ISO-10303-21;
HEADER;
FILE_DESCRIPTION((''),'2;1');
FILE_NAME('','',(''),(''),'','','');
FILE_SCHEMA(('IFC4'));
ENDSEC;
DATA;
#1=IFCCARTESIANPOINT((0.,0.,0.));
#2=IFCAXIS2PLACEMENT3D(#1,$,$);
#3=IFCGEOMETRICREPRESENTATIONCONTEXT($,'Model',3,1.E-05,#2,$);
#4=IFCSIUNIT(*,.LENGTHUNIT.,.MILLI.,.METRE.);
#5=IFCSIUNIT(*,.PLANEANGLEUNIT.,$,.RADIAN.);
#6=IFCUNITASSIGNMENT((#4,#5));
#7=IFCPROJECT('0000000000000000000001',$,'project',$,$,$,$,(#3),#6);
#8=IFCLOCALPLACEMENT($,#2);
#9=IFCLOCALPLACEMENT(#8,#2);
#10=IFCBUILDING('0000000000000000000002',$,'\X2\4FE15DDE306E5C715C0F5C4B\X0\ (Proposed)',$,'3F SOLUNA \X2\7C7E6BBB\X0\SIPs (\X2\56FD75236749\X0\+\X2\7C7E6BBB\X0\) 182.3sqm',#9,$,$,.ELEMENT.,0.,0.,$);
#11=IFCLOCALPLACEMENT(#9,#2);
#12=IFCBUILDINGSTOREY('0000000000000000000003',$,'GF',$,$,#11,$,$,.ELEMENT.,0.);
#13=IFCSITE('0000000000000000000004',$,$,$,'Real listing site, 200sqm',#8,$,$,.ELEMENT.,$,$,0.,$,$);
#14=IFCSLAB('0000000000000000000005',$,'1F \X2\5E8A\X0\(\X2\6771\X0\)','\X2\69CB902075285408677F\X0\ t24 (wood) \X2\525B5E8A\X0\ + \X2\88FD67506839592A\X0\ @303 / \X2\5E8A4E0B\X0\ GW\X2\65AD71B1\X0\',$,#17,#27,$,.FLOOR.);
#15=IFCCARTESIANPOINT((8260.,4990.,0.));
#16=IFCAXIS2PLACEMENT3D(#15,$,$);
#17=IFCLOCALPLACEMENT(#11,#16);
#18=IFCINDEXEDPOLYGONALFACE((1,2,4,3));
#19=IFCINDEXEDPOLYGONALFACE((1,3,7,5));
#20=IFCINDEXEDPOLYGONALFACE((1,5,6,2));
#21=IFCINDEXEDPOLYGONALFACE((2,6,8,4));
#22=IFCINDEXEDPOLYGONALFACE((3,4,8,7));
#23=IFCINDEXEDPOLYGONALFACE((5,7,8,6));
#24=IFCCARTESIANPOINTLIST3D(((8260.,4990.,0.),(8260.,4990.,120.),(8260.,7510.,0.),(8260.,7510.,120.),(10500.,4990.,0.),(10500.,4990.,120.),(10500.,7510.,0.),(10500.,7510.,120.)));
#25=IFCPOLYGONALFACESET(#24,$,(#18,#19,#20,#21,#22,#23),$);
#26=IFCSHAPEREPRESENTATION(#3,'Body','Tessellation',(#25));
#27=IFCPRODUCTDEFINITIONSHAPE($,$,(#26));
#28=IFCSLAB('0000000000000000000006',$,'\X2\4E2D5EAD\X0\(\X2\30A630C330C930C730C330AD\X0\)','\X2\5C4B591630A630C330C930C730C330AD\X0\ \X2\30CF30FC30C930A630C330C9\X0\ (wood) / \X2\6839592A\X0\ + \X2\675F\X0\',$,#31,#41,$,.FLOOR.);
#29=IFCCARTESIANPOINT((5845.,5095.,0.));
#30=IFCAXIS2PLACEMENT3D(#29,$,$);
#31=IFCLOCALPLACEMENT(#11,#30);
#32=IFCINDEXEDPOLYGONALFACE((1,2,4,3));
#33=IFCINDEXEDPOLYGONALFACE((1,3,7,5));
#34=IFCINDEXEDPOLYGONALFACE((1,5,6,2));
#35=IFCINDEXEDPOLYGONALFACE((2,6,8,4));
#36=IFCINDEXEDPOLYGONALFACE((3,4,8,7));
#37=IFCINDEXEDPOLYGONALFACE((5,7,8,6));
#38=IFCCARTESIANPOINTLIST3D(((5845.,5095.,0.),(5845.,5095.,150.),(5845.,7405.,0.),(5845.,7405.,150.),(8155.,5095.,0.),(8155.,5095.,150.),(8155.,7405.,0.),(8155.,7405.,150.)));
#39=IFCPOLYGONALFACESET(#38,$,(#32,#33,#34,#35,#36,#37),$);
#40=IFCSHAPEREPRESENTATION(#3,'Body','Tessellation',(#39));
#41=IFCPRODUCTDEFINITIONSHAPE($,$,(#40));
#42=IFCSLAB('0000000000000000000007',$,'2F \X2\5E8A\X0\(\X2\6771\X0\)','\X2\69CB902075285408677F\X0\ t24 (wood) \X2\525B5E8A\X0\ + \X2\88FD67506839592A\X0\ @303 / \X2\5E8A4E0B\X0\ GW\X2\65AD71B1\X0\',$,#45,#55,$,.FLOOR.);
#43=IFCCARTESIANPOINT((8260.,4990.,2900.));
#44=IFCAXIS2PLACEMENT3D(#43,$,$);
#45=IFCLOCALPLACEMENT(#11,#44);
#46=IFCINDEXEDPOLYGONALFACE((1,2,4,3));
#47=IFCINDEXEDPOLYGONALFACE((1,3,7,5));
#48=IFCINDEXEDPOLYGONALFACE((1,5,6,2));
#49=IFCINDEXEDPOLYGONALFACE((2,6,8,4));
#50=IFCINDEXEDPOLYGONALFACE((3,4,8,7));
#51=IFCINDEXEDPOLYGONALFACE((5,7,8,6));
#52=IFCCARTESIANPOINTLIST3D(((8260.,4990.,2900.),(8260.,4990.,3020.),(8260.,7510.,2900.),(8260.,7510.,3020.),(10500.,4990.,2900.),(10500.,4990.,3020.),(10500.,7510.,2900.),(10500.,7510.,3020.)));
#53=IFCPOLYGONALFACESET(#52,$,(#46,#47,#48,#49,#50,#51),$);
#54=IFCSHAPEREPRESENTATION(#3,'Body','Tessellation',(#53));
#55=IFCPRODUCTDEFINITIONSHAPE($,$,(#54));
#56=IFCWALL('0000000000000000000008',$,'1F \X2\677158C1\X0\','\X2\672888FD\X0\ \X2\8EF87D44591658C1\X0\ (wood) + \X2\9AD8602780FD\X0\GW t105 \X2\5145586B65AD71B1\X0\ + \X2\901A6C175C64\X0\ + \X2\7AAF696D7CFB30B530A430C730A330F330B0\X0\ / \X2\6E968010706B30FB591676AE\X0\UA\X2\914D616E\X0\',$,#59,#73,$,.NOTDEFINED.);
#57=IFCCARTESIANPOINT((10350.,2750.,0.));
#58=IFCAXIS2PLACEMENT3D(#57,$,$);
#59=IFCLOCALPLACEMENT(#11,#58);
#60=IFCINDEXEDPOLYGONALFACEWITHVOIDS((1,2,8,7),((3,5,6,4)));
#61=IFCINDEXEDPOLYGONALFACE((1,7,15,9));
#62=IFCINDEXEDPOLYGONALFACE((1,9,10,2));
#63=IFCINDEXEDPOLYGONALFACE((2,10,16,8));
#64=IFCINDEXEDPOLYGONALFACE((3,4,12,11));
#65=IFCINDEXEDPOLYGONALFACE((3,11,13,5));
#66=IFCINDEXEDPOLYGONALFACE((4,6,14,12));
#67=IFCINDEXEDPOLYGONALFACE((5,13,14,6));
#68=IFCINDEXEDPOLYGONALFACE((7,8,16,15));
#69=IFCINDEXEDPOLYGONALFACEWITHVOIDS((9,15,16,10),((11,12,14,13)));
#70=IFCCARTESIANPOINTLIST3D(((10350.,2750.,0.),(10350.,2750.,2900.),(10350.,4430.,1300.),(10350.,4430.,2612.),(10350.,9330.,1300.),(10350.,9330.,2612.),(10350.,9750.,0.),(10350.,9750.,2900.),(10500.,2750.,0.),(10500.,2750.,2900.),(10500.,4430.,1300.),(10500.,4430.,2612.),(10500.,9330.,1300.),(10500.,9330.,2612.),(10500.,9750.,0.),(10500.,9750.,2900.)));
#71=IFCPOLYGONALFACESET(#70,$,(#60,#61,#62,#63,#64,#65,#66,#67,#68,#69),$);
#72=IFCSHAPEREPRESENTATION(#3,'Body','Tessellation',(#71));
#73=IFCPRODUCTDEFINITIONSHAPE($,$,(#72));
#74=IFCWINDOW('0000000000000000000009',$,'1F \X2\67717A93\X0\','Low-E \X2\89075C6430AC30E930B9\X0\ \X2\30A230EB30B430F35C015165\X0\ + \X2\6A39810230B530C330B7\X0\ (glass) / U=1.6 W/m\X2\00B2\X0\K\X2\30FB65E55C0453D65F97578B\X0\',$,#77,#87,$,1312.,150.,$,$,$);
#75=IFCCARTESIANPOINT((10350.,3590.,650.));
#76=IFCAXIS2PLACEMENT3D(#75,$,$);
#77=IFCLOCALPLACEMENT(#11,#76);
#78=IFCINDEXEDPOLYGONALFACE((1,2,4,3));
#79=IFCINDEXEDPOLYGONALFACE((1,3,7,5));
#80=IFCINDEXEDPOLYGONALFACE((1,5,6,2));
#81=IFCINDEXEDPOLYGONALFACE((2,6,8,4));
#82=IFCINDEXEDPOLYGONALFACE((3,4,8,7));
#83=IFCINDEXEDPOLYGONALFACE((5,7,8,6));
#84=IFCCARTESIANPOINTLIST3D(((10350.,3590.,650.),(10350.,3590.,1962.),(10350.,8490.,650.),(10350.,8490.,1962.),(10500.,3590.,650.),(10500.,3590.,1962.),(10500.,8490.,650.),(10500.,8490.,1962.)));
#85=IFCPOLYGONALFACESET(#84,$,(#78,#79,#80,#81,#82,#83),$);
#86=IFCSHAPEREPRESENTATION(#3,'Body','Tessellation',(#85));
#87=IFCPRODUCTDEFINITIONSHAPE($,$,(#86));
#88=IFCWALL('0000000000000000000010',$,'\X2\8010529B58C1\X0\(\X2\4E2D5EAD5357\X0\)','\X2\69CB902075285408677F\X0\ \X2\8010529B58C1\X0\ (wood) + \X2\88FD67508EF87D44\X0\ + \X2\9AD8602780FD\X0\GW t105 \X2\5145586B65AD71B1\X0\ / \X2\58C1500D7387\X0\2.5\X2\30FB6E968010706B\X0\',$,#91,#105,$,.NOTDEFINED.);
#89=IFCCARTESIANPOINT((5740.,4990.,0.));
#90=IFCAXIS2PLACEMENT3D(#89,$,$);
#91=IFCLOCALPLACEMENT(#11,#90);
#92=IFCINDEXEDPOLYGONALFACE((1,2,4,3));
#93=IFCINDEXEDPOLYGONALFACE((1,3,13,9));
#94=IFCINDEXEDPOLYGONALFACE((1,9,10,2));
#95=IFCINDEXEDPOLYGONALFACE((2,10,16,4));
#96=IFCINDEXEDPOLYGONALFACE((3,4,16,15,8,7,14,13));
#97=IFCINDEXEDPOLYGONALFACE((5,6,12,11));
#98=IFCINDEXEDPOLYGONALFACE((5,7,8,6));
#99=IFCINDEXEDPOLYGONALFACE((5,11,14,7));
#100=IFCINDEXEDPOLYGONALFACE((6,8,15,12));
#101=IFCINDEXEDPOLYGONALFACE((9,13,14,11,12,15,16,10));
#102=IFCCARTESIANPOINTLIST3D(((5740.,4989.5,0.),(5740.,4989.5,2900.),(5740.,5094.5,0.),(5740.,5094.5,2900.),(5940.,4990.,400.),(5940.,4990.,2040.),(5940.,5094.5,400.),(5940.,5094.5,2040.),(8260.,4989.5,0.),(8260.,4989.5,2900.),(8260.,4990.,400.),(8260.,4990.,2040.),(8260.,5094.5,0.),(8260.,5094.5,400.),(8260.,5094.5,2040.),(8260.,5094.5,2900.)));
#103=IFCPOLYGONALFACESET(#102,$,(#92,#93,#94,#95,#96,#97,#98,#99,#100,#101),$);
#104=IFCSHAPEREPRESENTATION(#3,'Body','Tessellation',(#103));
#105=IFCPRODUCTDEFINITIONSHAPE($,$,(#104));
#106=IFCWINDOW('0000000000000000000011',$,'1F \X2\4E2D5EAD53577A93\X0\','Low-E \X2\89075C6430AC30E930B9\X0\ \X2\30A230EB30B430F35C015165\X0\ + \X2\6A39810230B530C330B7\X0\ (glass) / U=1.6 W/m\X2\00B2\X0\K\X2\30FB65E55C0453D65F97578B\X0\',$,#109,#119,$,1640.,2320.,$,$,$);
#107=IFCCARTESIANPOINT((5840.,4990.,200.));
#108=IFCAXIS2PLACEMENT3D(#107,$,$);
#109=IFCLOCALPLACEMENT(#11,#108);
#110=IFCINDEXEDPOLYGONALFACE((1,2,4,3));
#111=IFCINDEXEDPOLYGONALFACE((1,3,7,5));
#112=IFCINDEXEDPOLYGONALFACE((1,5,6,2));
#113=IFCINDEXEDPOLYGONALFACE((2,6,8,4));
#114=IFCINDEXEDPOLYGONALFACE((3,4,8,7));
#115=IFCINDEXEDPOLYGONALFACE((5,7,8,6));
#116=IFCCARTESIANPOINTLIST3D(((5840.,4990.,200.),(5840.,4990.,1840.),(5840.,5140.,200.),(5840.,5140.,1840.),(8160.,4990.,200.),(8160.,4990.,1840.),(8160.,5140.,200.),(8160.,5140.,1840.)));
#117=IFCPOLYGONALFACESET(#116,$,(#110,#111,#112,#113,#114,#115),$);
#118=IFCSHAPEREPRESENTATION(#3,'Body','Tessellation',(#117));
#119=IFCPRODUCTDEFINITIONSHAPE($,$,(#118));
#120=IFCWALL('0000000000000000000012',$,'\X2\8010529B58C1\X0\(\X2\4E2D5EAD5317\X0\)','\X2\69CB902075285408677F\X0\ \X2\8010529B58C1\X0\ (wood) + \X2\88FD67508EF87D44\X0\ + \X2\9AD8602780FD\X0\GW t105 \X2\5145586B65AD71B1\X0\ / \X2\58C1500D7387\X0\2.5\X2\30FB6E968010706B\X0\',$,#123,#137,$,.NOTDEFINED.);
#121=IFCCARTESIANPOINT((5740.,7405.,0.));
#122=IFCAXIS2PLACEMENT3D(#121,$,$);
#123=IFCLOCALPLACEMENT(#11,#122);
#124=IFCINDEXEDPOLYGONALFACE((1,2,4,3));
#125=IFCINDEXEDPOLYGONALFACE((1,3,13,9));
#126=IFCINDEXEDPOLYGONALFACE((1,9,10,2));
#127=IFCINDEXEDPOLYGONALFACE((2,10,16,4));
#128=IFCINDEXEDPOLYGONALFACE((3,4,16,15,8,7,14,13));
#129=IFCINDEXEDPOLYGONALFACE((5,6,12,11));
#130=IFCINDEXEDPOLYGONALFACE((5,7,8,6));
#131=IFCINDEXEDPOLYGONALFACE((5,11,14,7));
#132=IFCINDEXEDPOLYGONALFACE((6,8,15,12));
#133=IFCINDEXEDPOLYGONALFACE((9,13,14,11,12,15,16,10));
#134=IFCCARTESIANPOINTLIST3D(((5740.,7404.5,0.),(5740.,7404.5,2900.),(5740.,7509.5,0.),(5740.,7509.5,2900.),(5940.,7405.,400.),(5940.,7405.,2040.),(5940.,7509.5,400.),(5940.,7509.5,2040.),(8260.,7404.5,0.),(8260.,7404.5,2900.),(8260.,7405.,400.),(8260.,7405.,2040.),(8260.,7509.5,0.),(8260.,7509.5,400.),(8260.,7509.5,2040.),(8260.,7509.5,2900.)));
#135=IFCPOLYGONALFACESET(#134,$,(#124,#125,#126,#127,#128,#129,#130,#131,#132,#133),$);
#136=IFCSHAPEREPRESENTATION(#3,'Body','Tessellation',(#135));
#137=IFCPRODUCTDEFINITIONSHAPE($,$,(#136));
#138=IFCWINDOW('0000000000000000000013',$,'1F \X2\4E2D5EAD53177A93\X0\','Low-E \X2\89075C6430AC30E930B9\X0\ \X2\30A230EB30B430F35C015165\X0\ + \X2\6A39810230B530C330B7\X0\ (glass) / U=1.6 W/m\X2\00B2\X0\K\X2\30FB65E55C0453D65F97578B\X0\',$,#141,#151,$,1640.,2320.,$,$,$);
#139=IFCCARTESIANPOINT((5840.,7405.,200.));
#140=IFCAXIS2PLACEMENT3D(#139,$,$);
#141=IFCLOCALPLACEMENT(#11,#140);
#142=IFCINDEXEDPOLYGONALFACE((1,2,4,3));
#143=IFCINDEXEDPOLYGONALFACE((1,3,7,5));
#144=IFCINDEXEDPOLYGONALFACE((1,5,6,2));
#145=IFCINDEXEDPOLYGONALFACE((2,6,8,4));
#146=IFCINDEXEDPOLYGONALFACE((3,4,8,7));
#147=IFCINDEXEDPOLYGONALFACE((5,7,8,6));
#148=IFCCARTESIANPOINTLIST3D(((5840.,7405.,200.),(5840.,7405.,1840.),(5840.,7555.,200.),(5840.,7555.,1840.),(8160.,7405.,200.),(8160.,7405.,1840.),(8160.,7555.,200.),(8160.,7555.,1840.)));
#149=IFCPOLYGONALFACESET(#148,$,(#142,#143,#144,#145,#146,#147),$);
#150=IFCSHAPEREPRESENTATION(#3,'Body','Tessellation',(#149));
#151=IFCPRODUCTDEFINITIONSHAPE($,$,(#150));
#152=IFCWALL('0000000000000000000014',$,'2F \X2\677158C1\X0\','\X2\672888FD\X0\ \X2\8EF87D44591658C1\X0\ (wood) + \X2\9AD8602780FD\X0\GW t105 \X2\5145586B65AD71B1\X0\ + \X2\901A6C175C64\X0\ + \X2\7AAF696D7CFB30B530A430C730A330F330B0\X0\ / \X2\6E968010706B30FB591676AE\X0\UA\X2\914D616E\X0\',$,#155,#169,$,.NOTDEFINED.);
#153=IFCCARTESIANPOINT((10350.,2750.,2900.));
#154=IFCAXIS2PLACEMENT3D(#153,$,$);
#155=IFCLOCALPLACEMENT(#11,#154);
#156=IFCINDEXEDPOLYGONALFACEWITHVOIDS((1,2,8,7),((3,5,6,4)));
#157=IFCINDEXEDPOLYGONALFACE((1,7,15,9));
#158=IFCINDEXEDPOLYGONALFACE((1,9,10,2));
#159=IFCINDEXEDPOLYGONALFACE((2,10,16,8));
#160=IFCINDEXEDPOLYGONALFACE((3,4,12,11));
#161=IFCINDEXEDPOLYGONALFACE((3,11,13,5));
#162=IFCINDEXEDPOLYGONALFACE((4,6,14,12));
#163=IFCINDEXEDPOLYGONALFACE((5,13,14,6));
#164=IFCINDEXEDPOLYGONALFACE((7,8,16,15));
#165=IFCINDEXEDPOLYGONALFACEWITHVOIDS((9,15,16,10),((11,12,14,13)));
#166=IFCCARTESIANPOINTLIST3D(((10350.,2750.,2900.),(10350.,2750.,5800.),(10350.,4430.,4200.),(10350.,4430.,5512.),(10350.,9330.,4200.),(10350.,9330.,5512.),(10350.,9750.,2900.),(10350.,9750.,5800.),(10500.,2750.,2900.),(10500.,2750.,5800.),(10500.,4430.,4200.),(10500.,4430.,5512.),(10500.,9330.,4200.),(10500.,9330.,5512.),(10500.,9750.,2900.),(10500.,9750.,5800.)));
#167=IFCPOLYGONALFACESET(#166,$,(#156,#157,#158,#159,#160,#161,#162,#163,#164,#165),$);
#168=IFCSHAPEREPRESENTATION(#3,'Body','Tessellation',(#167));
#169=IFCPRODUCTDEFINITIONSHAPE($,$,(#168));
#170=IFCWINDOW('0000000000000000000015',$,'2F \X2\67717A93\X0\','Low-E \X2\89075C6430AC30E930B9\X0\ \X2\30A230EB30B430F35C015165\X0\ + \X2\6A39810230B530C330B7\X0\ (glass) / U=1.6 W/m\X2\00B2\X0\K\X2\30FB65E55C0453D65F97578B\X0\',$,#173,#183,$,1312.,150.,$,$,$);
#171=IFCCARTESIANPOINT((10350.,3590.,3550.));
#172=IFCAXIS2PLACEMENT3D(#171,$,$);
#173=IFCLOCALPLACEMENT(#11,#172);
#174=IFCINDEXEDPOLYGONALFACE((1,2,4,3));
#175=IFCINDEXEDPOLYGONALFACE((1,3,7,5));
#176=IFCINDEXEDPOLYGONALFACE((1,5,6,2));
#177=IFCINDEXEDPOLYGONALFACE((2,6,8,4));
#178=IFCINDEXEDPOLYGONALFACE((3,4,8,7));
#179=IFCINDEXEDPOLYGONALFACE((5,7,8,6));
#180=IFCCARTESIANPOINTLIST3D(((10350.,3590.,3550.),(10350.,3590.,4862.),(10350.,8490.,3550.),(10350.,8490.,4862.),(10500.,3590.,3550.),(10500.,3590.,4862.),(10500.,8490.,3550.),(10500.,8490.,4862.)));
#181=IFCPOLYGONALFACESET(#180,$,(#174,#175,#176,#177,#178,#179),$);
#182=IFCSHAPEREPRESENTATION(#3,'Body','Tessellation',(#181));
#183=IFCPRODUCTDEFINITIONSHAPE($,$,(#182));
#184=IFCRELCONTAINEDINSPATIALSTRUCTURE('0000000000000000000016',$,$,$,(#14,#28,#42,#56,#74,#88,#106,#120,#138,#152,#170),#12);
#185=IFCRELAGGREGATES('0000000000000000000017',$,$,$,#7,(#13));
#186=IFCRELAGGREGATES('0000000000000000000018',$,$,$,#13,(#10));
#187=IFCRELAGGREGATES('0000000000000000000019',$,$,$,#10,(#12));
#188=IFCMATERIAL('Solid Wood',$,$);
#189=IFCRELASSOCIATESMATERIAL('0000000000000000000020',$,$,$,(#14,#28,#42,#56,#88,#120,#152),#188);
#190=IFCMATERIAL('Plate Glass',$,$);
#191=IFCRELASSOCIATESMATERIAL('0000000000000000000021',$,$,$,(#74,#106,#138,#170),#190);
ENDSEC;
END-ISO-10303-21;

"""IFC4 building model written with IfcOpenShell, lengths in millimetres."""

from ifc_helpers import new_model, si_unit, frame, frame_2d, origin, place, context, project, spatial, rectangle, extrude, material, element, fill, save


model = new_model("IFC4")

# Units and contexts
model_context = context("Model", 3, precision=1e-05, world=origin())
ifc_project = project(units=[si_unit("LENGTHUNIT", "METRE", prefix="MILLI"), si_unit("PLANEANGLEUNIT", "RADIAN")], contexts=[model_context])

# Site, building, storey
site_placement = place(None, origin())
site = spatial("IfcSite", under=ifc_project, at=site_placement, ObjectType="Real listing site, 200sqm", CompositionType="ELEMENT", RefElevation=0.0)
building_placement = place(site_placement, origin())
building = spatial("IfcBuilding", under=site, at=building_placement, Name="信州の山小屋 (Proposed)", ObjectType="3F SOLUNA 籾殻SIPs (国産杉+籾殻) 182.3sqm", CompositionType="ELEMENT", ElevationOfRefHeight=0.0, ElevationOfTerrain=0.0)
storey_placement = place(building_placement, origin())
storey = spatial("IfcBuildingStorey", under=building, at=storey_placement, Name="GF", CompositionType="ELEMENT", Elevation=0.0)

# Slabs
ifc_material_1 = material(Name="Solid Wood")
slab_1_placement = place(storey_placement, frame((8260.0, 4990.0, 0.0)))
element("IfcSlab", 1, at=slab_1_placement, inside=storey, material=ifc_material_1, Name="1F 床(東)", Description="構造用合板 t24 (wood) 剛床 + 製材根太 @303 / 床下 GW断熱", PredefinedType="FLOOR", context=model_context, shape_type="SweptSolid", body=[
    extrude(rectangle(XDim=2240.0, YDim=2520.0, at=frame_2d((1120.0, 1260.0))), frame((8260.0, 4990.0, 0.0)), (0.0, 0.0, 1.0), 120.0),
])
slab_2_placement = place(storey_placement, frame((5845.0, 5095.0, 0.0)))
element("IfcSlab", 2, at=slab_2_placement, inside=storey, material=ifc_material_1, Name="中庭(ウッドデッキ)", Description="屋外ウッドデッキ ハードウッド (wood) / 根太 + 束", PredefinedType="FLOOR", context=model_context, shape_type="SweptSolid", body=[
    extrude(rectangle(XDim=2310.0, YDim=2310.0, at=frame_2d((1155.0, 1155.0))), frame((5845.0, 5095.0, 0.0)), (0.0, 0.0, 1.0), 150.0),
])
slab_3_placement = place(storey_placement, frame((8260.0, 4990.0, 2900.0)))
element("IfcSlab", 3, at=slab_3_placement, inside=storey, material=ifc_material_1, Name="2F 床(東)", Description="構造用合板 t24 (wood) 剛床 + 製材根太 @303 / 床下 GW断熱", PredefinedType="FLOOR", context=model_context, shape_type="SweptSolid", body=[
    extrude(rectangle(XDim=2240.0, YDim=2520.0, at=frame_2d((1120.0, 1260.0))), frame((8260.0, 4990.0, 2900.0)), (0.0, 0.0, 1.0), 120.0),
])

# Walls, openings, windows
wall_1_placement = place(storey_placement, frame((10350.0, 2750.0, 0.0)))
wall_1 = element("IfcWall", 4, at=wall_1_placement, inside=storey, material=ifc_material_1, Name="1F 東壁", Description="木製 軸組外壁 (wood) + 高性能GW t105 充填断熱 + 通気層 + 窯業系サイディング / 準耐火・外皮UA配慮", PredefinedType="NOTDEFINED", context=model_context, shape_type="SweptSolid", body=[
    extrude(rectangle(XDim=150.0, YDim=7000.0, at=frame_2d((75.0, 3500.0))), frame((10350.0, 2750.0, 0.0)), (0.0, 0.0, 1.0), 2900.0),
])
opening_1_placement = place(storey_placement, frame((10350.0, 3590.0, 650.0)))
opening_1 = element("IfcOpeningElement", 5, at=opening_1_placement, cuts=wall_1, PredefinedType="NOTDEFINED", context=model_context, shape_type="SweptSolid", body=[
    extrude(rectangle(XDim=150.0, YDim=4900.0, at=frame_2d((75.0, 2450.0))), frame((10350.0, 3590.0, 650.0)), (0.0, 0.0, 1.0), 1312.0),
])
ifc_material_2 = material(Name="Plate Glass")
window_1_placement = place(storey_placement, frame((10350.0, 3590.0, 650.0)))
window_1 = element("IfcWindow", 6, at=window_1_placement, inside=storey, material=ifc_material_2, Name="1F 東窓", Description="Low-E 複層ガラス アルゴン封入 + 樹脂サッシ (glass) / U=1.6 W/m²K・日射取得型", OverallHeight=1312.0, OverallWidth=150.0, context=model_context, shape_type="SweptSolid", body=[
    extrude(rectangle(XDim=150.0, YDim=4900.0, at=frame_2d((75.0, 2450.0))), frame((10350.0, 3590.0, 650.0)), (0.0, 0.0, 1.0), 1312.0),
])
fill(opening_1, window_1)
wall_2_placement = place(storey_placement, frame((5740.0, 4990.0, 0.0)))
wall_2 = element("IfcWall", 7, at=wall_2_placement, inside=storey, material=ifc_material_1, Name="耐力壁(中庭南)", Description="構造用合板 耐力壁 (wood) + 製材軸組 + 高性能GW t105 充填断熱 / 壁倍率2.5・準耐火", PredefinedType="NOTDEFINED", context=model_context, shape_type="SweptSolid", body=[
    extrude(rectangle(XDim=2520.0, YDim=105.0, at=frame_2d((1260.0, 52.0))), frame((5740.0, 4990.0, 0.0)), (0.0, 0.0, 1.0), 2900.0),
])
opening_2_placement = place(storey_placement, frame((5840.0, 4990.0, 200.0)))
opening_2 = element("IfcOpeningElement", 8, at=opening_2_placement, cuts=wall_2, PredefinedType="NOTDEFINED", context=model_context, shape_type="SweptSolid", body=[
    extrude(rectangle(XDim=2320.0, YDim=150.0, at=frame_2d((1160.0, 75.0))), frame((5840.0, 4990.0, 200.0)), (0.0, 0.0, 1.0), 1640.0),
])
window_2_placement = place(storey_placement, frame((5840.0, 4990.0, 200.0)))
window_2 = element("IfcWindow", 9, at=window_2_placement, inside=storey, material=ifc_material_2, Name="1F 中庭南窓", Description="Low-E 複層ガラス アルゴン封入 + 樹脂サッシ (glass) / U=1.6 W/m²K・日射取得型", OverallHeight=1640.0, OverallWidth=2320.0, context=model_context, shape_type="SweptSolid", body=[
    extrude(rectangle(XDim=2320.0, YDim=150.0, at=frame_2d((1160.0, 75.0))), frame((5840.0, 4990.0, 200.0)), (0.0, 0.0, 1.0), 1640.0),
])
fill(opening_2, window_2)
wall_3_placement = place(storey_placement, frame((5740.0, 7405.0, 0.0)))
wall_3 = element("IfcWall", 10, at=wall_3_placement, inside=storey, material=ifc_material_1, Name="耐力壁(中庭北)", Description="構造用合板 耐力壁 (wood) + 製材軸組 + 高性能GW t105 充填断熱 / 壁倍率2.5・準耐火", PredefinedType="NOTDEFINED", context=model_context, shape_type="SweptSolid", body=[
    extrude(rectangle(XDim=2520.0, YDim=105.0, at=frame_2d((1260.0, 52.0))), frame((5740.0, 7405.0, 0.0)), (0.0, 0.0, 1.0), 2900.0),
])
opening_3_placement = place(storey_placement, frame((5840.0, 7405.0, 200.0)))
opening_3 = element("IfcOpeningElement", 11, at=opening_3_placement, cuts=wall_3, PredefinedType="NOTDEFINED", context=model_context, shape_type="SweptSolid", body=[
    extrude(rectangle(XDim=2320.0, YDim=150.0, at=frame_2d((1160.0, 75.0))), frame((5840.0, 7405.0, 200.0)), (0.0, 0.0, 1.0), 1640.0),
])
window_3_placement = place(storey_placement, frame((5840.0, 7405.0, 200.0)))
window_3 = element("IfcWindow", 12, at=window_3_placement, inside=storey, material=ifc_material_2, Name="1F 中庭北窓", Description="Low-E 複層ガラス アルゴン封入 + 樹脂サッシ (glass) / U=1.6 W/m²K・日射取得型", OverallHeight=1640.0, OverallWidth=2320.0, context=model_context, shape_type="SweptSolid", body=[
    extrude(rectangle(XDim=2320.0, YDim=150.0, at=frame_2d((1160.0, 75.0))), frame((5840.0, 7405.0, 200.0)), (0.0, 0.0, 1.0), 1640.0),
])
fill(opening_3, window_3)

# Wall, opening, window
wall_4_placement = place(storey_placement, frame((10350.0, 2750.0, 2900.0)))
wall_4 = element("IfcWall", 13, at=wall_4_placement, inside=storey, material=ifc_material_1, Name="2F 東壁", Description="木製 軸組外壁 (wood) + 高性能GW t105 充填断熱 + 通気層 + 窯業系サイディング / 準耐火・外皮UA配慮", PredefinedType="NOTDEFINED", context=model_context, shape_type="SweptSolid", body=[
    extrude(rectangle(XDim=150.0, YDim=7000.0, at=frame_2d((75.0, 3500.0))), frame((10350.0, 2750.0, 2900.0)), (0.0, 0.0, 1.0), 2900.0),
])
opening_4_placement = place(storey_placement, frame((10350.0, 3590.0, 3550.0)))
opening_4 = element("IfcOpeningElement", 14, at=opening_4_placement, cuts=wall_4, PredefinedType="NOTDEFINED", context=model_context, shape_type="SweptSolid", body=[
    extrude(rectangle(XDim=150.0, YDim=4900.0, at=frame_2d((75.0, 2450.0))), frame((10350.0, 3590.0, 3550.0)), (0.0, 0.0, 1.0), 1312.0),
])
window_4_placement = place(storey_placement, frame((10350.0, 3590.0, 3550.0)))
window_4 = element("IfcWindow", 15, at=window_4_placement, inside=storey, material=ifc_material_2, Name="2F 東窓", Description="Low-E 複層ガラス アルゴン封入 + 樹脂サッシ (glass) / U=1.6 W/m²K・日射取得型", OverallHeight=1312.0, OverallWidth=150.0, context=model_context, shape_type="SweptSolid", body=[
    extrude(rectangle(XDim=150.0, YDim=4900.0, at=frame_2d((75.0, 2450.0))), frame((10350.0, 3590.0, 3550.0)), (0.0, 0.0, 1.0), 1312.0),
])
fill(opening_4, window_4)

save(model, "model.ifc")
